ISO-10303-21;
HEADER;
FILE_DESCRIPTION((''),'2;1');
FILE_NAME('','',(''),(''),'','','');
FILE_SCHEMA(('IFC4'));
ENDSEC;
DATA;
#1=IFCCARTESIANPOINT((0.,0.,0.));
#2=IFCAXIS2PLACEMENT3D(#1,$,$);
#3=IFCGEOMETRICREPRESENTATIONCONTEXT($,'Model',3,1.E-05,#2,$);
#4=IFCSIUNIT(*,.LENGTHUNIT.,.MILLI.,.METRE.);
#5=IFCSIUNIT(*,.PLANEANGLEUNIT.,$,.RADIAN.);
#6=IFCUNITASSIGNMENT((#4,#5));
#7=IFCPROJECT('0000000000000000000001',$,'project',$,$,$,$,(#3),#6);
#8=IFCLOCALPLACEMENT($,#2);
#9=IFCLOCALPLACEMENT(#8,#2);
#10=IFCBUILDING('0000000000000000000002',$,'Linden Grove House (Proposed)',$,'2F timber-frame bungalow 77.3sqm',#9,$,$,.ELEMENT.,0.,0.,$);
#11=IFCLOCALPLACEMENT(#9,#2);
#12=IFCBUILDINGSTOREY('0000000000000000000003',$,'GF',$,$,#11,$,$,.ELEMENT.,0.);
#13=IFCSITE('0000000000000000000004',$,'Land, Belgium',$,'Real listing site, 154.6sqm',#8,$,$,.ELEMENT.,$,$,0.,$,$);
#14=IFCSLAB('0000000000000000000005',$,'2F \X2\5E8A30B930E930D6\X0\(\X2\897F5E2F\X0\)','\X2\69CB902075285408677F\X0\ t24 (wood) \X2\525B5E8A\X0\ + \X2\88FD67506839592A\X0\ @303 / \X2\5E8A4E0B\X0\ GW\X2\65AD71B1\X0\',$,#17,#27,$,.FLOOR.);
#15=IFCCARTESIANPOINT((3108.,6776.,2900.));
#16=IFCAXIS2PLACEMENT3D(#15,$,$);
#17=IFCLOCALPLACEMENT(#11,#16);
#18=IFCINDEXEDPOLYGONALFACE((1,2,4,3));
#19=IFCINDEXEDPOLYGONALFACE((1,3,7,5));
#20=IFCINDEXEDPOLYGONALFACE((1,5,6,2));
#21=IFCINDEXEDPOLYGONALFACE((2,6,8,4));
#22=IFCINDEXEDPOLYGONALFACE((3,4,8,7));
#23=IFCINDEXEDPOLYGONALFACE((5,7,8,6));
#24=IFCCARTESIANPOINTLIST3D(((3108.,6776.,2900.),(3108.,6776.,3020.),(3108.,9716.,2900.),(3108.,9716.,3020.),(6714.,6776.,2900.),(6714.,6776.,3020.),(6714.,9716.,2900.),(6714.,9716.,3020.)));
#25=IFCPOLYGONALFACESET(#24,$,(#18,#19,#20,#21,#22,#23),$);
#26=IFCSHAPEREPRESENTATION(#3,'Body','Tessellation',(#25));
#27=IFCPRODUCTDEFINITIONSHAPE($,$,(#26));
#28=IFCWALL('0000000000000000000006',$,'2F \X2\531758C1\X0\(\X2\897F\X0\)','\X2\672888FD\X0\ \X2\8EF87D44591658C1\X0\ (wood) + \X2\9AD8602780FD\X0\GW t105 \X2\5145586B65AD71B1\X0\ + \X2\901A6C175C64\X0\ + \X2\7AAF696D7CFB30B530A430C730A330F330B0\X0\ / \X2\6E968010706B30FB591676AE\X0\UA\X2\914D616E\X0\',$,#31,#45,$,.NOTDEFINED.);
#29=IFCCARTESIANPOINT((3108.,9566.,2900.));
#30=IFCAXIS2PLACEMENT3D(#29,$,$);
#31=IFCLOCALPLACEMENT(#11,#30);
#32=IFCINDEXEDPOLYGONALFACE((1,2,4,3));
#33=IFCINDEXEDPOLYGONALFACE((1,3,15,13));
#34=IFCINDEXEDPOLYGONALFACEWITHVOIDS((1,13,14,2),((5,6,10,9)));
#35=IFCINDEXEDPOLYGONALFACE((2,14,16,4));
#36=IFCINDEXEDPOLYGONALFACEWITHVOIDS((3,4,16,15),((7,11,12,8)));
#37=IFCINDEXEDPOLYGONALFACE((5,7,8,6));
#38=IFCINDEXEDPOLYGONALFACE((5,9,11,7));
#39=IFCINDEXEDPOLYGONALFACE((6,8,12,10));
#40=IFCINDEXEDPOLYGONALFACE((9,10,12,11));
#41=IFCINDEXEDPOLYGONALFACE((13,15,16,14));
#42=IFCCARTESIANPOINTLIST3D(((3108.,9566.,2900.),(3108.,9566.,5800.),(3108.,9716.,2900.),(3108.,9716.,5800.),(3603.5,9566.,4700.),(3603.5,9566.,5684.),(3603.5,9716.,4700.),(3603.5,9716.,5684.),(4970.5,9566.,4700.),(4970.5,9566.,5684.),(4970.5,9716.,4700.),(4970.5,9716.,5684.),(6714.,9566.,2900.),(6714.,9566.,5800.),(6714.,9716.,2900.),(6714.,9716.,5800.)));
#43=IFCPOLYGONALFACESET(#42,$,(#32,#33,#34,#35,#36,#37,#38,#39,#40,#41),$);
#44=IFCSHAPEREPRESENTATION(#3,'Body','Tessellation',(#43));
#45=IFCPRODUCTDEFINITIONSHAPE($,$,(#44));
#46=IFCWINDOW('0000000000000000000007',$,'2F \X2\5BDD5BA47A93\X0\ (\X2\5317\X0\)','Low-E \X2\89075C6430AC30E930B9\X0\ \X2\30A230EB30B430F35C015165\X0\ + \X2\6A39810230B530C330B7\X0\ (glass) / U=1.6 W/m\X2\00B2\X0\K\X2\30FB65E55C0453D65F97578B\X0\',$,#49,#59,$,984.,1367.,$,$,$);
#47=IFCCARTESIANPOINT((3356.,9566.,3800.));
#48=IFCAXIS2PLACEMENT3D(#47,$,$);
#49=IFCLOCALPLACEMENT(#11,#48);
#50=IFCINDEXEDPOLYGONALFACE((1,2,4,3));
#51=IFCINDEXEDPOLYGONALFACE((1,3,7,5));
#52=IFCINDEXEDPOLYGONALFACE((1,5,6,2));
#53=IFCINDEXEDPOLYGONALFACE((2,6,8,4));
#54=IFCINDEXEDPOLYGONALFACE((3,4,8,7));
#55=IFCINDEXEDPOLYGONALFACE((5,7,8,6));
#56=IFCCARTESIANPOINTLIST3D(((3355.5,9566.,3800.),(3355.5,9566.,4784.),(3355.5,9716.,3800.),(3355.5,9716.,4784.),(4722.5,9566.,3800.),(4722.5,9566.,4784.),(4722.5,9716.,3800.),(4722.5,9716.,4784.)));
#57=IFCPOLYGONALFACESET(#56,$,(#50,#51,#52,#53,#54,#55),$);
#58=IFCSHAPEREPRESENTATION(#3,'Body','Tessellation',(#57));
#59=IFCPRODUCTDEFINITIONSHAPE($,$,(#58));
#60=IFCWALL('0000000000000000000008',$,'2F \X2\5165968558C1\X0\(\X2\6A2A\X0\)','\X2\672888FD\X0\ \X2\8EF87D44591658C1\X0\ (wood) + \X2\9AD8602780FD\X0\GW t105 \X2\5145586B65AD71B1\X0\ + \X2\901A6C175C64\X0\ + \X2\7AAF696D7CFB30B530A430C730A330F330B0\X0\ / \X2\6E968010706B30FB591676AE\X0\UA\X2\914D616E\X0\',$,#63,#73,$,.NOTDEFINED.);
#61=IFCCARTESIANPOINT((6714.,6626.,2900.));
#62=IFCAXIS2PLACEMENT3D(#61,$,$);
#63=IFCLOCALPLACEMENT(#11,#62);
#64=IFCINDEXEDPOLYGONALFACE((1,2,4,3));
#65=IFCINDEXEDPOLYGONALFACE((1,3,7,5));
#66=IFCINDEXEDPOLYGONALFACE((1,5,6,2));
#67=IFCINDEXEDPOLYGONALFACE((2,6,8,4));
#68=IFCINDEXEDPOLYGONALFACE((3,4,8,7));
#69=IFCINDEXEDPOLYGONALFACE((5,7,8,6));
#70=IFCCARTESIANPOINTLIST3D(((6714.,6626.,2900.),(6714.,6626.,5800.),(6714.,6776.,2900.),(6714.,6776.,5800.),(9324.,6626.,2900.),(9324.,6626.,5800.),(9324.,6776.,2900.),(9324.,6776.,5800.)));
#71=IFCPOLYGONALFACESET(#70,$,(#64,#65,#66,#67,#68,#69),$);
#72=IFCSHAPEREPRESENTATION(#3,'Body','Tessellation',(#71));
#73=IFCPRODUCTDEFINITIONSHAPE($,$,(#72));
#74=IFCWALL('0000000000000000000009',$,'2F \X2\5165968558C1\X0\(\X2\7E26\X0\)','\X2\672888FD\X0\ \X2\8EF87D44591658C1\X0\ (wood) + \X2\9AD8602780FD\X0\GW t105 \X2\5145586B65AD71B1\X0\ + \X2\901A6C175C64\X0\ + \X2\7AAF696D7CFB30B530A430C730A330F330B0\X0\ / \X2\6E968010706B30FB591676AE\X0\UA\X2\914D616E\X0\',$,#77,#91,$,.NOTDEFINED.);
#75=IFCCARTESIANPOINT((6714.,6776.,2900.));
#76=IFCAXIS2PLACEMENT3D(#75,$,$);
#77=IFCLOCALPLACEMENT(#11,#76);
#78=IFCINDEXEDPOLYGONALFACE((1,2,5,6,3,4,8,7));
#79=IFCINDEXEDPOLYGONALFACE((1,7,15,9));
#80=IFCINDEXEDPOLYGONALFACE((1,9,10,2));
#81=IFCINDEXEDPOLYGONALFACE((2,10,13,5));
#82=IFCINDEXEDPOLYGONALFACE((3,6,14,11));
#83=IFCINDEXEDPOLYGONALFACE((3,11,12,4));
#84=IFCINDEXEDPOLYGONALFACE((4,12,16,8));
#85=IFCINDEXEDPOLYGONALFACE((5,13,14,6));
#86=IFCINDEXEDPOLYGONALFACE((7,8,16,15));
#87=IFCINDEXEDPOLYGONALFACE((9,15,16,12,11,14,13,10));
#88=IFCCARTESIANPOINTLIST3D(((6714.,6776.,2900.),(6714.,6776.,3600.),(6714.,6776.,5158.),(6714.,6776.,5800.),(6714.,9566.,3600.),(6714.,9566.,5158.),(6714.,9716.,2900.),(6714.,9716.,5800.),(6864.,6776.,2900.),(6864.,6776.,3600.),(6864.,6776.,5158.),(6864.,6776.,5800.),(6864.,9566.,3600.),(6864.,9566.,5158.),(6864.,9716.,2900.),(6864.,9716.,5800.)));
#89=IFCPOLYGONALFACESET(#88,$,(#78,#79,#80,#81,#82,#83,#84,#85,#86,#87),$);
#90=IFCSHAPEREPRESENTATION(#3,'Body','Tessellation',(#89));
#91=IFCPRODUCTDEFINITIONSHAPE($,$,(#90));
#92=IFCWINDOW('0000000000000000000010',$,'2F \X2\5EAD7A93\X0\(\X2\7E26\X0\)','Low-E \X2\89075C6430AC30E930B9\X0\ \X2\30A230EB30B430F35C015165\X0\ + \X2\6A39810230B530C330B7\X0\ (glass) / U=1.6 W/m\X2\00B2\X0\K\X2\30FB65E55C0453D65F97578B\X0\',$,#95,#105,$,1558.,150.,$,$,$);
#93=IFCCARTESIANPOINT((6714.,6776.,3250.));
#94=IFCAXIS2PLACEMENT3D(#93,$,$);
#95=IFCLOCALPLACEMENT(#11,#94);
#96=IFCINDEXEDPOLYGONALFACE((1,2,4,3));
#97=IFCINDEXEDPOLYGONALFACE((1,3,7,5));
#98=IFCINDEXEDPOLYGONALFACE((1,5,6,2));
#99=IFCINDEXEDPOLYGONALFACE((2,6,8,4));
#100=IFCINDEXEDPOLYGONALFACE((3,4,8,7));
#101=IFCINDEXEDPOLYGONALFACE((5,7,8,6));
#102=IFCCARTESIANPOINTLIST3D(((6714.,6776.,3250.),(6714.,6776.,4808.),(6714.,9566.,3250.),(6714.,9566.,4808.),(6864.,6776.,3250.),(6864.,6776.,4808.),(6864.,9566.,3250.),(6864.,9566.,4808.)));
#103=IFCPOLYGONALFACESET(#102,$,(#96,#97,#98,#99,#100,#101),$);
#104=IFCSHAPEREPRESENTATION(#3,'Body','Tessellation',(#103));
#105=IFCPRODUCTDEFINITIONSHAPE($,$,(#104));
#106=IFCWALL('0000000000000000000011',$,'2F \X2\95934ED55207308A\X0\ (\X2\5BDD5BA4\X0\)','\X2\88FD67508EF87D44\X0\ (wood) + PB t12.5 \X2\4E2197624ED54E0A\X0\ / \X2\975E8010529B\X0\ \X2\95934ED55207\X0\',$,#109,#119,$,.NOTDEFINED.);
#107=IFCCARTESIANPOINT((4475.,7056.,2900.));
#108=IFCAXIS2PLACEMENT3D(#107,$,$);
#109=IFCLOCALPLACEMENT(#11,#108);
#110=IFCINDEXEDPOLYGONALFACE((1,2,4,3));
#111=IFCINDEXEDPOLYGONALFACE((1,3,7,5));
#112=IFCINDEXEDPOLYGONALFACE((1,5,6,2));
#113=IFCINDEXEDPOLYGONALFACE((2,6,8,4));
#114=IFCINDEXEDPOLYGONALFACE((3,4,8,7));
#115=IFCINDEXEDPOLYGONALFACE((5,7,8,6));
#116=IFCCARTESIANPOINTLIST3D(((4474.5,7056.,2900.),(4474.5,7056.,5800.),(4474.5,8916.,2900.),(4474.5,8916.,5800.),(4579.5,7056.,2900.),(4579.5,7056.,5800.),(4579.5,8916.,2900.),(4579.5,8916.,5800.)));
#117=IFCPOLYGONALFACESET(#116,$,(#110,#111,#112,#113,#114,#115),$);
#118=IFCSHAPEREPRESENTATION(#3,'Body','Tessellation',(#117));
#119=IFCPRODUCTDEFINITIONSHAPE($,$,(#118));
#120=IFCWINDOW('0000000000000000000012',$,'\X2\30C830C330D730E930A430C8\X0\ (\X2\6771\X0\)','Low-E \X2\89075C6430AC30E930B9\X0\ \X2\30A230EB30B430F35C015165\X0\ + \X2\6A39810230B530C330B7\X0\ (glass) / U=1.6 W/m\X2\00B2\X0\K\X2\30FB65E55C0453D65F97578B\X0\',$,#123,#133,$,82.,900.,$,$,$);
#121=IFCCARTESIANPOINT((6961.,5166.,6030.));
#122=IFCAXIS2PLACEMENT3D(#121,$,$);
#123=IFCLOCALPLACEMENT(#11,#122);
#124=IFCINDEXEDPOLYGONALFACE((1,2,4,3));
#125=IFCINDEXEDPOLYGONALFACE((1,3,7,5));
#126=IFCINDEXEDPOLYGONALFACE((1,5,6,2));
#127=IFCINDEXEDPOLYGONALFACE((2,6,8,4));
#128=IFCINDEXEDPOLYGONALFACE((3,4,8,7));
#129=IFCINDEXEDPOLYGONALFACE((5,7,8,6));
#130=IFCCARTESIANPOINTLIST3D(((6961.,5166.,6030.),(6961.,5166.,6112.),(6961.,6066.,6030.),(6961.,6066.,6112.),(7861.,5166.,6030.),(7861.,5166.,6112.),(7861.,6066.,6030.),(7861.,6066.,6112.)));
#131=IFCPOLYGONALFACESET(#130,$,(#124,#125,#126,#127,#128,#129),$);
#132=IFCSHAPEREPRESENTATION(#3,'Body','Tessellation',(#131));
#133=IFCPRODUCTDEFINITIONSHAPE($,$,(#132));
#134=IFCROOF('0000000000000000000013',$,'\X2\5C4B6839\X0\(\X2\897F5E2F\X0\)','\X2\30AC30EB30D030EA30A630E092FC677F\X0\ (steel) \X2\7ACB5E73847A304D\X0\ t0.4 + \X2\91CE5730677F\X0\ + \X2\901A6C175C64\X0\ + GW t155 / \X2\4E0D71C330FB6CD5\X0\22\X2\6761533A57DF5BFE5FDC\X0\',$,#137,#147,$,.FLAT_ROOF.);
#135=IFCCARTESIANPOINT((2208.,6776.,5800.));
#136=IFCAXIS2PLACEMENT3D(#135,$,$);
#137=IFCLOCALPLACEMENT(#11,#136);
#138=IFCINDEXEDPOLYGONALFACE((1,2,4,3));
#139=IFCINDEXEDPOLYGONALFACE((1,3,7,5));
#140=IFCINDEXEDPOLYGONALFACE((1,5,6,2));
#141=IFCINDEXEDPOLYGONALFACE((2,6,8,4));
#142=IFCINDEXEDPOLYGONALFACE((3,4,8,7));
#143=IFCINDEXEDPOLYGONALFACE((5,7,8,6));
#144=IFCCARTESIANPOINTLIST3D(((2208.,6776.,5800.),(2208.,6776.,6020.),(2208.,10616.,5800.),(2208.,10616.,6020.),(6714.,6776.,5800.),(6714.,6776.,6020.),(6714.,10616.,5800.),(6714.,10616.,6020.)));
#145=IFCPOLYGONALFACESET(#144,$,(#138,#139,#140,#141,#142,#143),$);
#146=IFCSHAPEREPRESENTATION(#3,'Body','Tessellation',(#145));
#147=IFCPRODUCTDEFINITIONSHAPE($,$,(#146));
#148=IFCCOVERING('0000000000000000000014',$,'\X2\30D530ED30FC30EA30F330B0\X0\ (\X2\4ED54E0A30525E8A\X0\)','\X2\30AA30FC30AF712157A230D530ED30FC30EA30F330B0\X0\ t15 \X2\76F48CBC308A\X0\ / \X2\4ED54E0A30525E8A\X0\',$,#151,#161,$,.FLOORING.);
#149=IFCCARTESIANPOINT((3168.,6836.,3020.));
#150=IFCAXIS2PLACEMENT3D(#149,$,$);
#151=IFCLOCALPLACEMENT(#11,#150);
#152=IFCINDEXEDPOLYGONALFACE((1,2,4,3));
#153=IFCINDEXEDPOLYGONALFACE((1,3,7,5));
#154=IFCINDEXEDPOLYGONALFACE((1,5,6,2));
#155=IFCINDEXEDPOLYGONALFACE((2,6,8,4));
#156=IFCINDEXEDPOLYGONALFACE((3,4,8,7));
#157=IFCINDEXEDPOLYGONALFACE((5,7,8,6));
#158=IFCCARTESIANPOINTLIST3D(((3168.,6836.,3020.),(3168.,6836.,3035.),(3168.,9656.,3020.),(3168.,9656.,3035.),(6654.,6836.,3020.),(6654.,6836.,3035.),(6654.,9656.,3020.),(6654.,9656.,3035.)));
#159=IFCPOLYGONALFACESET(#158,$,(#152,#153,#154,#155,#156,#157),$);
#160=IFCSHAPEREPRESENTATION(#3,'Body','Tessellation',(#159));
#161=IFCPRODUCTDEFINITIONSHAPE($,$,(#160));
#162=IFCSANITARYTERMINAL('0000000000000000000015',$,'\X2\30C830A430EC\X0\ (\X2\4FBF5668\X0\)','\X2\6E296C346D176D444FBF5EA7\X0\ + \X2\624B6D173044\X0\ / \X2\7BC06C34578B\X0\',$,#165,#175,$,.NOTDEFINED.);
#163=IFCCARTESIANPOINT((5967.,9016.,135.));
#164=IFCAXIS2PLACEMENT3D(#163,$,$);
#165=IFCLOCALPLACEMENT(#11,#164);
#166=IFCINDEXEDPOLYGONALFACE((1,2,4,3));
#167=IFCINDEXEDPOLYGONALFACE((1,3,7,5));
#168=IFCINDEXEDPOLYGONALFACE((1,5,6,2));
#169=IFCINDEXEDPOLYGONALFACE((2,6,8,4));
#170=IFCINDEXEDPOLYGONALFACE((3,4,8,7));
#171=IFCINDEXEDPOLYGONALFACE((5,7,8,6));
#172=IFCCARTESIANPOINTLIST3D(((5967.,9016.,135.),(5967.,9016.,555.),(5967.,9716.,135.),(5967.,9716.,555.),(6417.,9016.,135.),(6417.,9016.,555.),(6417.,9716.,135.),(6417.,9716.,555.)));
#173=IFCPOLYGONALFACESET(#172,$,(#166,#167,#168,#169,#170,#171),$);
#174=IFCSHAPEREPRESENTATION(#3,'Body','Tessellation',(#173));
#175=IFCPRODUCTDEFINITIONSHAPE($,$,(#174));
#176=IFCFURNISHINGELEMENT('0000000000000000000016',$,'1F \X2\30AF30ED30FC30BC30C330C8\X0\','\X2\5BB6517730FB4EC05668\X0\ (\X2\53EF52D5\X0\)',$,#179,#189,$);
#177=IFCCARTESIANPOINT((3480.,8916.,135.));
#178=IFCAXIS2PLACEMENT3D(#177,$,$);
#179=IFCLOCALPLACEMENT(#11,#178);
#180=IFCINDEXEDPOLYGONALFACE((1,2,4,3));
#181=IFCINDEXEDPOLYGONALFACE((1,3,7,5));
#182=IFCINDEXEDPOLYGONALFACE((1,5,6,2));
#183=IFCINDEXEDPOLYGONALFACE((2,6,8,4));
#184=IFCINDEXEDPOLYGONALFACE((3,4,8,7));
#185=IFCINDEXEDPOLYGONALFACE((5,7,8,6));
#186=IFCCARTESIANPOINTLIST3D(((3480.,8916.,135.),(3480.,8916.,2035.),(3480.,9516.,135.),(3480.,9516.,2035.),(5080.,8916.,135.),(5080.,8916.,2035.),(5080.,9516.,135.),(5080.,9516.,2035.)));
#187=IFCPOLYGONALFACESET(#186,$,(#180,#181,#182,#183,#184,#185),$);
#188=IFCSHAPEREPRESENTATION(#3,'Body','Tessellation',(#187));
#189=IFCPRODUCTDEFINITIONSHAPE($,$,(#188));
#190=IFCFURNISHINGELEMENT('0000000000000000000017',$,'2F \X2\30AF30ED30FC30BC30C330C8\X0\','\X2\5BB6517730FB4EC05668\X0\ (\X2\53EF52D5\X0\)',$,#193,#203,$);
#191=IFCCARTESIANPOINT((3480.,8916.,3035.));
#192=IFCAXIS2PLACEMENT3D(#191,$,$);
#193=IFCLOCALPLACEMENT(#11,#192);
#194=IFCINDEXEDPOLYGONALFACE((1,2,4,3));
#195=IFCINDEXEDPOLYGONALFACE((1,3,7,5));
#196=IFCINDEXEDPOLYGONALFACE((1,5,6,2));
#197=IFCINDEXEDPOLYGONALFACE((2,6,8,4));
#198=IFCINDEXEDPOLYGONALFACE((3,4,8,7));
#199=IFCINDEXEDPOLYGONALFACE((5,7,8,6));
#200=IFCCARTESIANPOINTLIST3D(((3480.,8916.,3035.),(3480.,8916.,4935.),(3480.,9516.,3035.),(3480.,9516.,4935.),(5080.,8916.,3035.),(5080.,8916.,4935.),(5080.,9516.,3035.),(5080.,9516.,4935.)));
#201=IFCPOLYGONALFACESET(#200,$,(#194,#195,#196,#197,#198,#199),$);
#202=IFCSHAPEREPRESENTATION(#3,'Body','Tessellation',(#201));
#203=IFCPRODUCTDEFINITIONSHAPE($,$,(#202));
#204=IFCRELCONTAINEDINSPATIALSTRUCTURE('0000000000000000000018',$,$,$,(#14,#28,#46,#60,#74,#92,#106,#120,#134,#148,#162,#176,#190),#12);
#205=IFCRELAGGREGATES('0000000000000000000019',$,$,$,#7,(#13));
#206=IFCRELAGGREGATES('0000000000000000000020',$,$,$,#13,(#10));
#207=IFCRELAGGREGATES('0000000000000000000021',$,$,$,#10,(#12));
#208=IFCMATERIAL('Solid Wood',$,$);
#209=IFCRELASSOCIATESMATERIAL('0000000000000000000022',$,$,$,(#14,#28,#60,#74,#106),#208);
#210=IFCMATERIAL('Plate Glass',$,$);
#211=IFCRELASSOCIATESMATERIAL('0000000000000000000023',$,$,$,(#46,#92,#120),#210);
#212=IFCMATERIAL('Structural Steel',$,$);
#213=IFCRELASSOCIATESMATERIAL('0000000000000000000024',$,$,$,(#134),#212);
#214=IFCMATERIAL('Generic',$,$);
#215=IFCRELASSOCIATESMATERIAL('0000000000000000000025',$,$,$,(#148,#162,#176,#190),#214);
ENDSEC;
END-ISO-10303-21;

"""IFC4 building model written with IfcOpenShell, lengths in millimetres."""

from ifc_helpers import new_model, si_unit, frame, frame_2d, origin, place, context, project, spatial, rectangle, extrude, material, element, fill, save


model = new_model("IFC4")

# Units and contexts
model_context = context("Model", 3, precision=1e-05, world=origin())
ifc_project = project(units=[si_unit("LENGTHUNIT", "METRE", prefix="MILLI"), si_unit("PLANEANGLEUNIT", "RADIAN")], contexts=[model_context])

# Site, building, storey
site_placement = place(None, origin())
site = spatial("IfcSite", under=ifc_project, at=site_placement, Name="Land, Belgium", ObjectType="Real listing site, 154.6sqm", CompositionType="ELEMENT", RefElevation=0.0)
building_placement = place(site_placement, origin())
building = spatial("IfcBuilding", under=site, at=building_placement, Name="Linden Grove House (Proposed)", ObjectType="2F timber-frame bungalow 77.3sqm", CompositionType="ELEMENT", ElevationOfRefHeight=0.0, ElevationOfTerrain=0.0)
storey_placement = place(building_placement, origin())
storey = spatial("IfcBuildingStorey", under=building, at=storey_placement, Name="GF", CompositionType="ELEMENT", Elevation=0.0)

# Slab
ifc_material_1 = material(Name="Solid Wood")
slab_placement = place(storey_placement, frame((3108.0, 6776.0, 2900.0)))
element("IfcSlab", 1, at=slab_placement, inside=storey, material=ifc_material_1, Name="2F 床スラブ(西帯)", Description="構造用合板 t24 (wood) 剛床 + 製材根太 @303 / 床下 GW断熱", PredefinedType="FLOOR", context=model_context, shape_type="SweptSolid", body=[
    extrude(rectangle(XDim=3606.0, YDim=2940.0, at=frame_2d((1803.0, 1470.0))), frame((3108.0, 6776.0, 2900.0)), (0.0, 0.0, 1.0), 120.0),
])

# Wall, opening, window
wall_1_placement = place(storey_placement, frame((3108.0, 9566.0, 2900.0)))
wall_1 = element("IfcWall", 2, at=wall_1_placement, inside=storey, material=ifc_material_1, Name="2F 北壁(西)", Description="木製 軸組外壁 (wood) + 高性能GW t105 充填断熱 + 通気層 + 窯業系サイディング / 準耐火・外皮UA配慮", PredefinedType="NOTDEFINED", context=model_context, shape_type="SweptSolid", body=[
    extrude(rectangle(XDim=3606.0, YDim=150.0, at=frame_2d((1803.0, 75.0))), frame((3108.0, 9566.0, 2900.0)), (0.0, 0.0, 1.0), 2900.0),
])
opening_1_placement = place(storey_placement, frame((3356.0, 9566.0, 3800.0)))
opening_1 = element("IfcOpeningElement", 3, at=opening_1_placement, cuts=wall_1, PredefinedType="NOTDEFINED", context=model_context, shape_type="SweptSolid", body=[
    extrude(rectangle(XDim=1367.0, YDim=150.0, at=frame_2d((683.0, 75.0))), frame((3356.0, 9566.0, 3800.0)), (0.0, 0.0, 1.0), 984.0),
])
ifc_material_2 = material(Name="Plate Glass")
window_1_placement = place(storey_placement, frame((3356.0, 9566.0, 3800.0)))
window_1 = element("IfcWindow", 4, at=window_1_placement, inside=storey, material=ifc_material_2, Name="2F 寝室窓 (北)", Description="Low-E 複層ガラス アルゴン封入 + 樹脂サッシ (glass) / U=1.6 W/m²K・日射取得型", OverallHeight=984.0, OverallWidth=1367.0, context=model_context, shape_type="SweptSolid", body=[
    extrude(rectangle(XDim=1367.0, YDim=150.0, at=frame_2d((683.0, 75.0))), frame((3356.0, 9566.0, 3800.0)), (0.0, 0.0, 1.0), 984.0),
])
fill(opening_1, window_1)

# Wall
wall_2_placement = place(storey_placement, frame((6714.0, 6626.0, 2900.0)))
element("IfcWall", 5, at=wall_2_placement, inside=storey, material=ifc_material_1, Name="2F 入隅壁(横)", Description="木製 軸組外壁 (wood) + 高性能GW t105 充填断熱 + 通気層 + 窯業系サイディング / 準耐火・外皮UA配慮", PredefinedType="NOTDEFINED", context=model_context, shape_type="SweptSolid", body=[
    extrude(rectangle(XDim=2610.0, YDim=150.0, at=frame_2d((1305.0, 75.0))), frame((6714.0, 6626.0, 2900.0)), (0.0, 0.0, 1.0), 2900.0),
])

# Wall, opening, window
wall_3_placement = place(storey_placement, frame((6714.0, 6776.0, 2900.0)))
wall_3 = element("IfcWall", 6, at=wall_3_placement, inside=storey, material=ifc_material_1, Name="2F 入隅壁(縦)", Description="木製 軸組外壁 (wood) + 高性能GW t105 充填断熱 + 通気層 + 窯業系サイディング / 準耐火・外皮UA配慮", PredefinedType="NOTDEFINED", context=model_context, shape_type="SweptSolid", body=[
    extrude(rectangle(XDim=150.0, YDim=2940.0, at=frame_2d((75.0, 1470.0))), frame((6714.0, 6776.0, 2900.0)), (0.0, 0.0, 1.0), 2900.0),
])
opening_2_placement = place(storey_placement, frame((6714.0, 6776.0, 3250.0)))
opening_2 = element("IfcOpeningElement", 7, at=opening_2_placement, cuts=wall_3, PredefinedType="NOTDEFINED", context=model_context, shape_type="SweptSolid", body=[
    extrude(rectangle(XDim=150.0, YDim=2790.0, at=frame_2d((75.0, 1395.0))), frame((6714.0, 6776.0, 3250.0)), (0.0, 0.0, 1.0), 1558.0),
])
window_2_placement = place(storey_placement, frame((6714.0, 6776.0, 3250.0)))
window_2 = element("IfcWindow", 8, at=window_2_placement, inside=storey, material=ifc_material_2, Name="2F 庭窓(縦)", Description="Low-E 複層ガラス アルゴン封入 + 樹脂サッシ (glass) / U=1.6 W/m²K・日射取得型", OverallHeight=1558.0, OverallWidth=150.0, context=model_context, shape_type="SweptSolid", body=[
    extrude(rectangle(XDim=150.0, YDim=2790.0, at=frame_2d((75.0, 1395.0))), frame((6714.0, 6776.0, 3250.0)), (0.0, 0.0, 1.0), 1558.0),
])
fill(opening_2, window_2)

# Wall
wall_4_placement = place(storey_placement, frame((4475.0, 7056.0, 2900.0)))
element("IfcWall", 9, at=wall_4_placement, inside=storey, material=ifc_material_1, Name="2F 間仕切り (寝室)", Description="製材軸組 (wood) + PB t12.5 両面仕上 / 非耐力 間仕切", PredefinedType="NOTDEFINED", context=model_context, shape_type="SweptSolid", body=[
    extrude(rectangle(XDim=105.0, YDim=1860.0, at=frame_2d((52.0, 930.0))), frame((4475.0, 7056.0, 2900.0)), (0.0, 0.0, 1.0), 2900.0),
])

# Window
window_3_placement = place(storey_placement, frame((6961.0, 5166.0, 6030.0)))
element("IfcWindow", 10, at=window_3_placement, inside=storey, material=ifc_material_2, Name="トップライト (東)", Description="Low-E 複層ガラス アルゴン封入 + 樹脂サッシ (glass) / U=1.6 W/m²K・日射取得型", OverallHeight=82.0, OverallWidth=900.0, context=model_context, shape_type="SweptSolid", body=[
    extrude(rectangle(XDim=900.0, YDim=900.0, at=frame_2d((450.0, 450.0))), frame((6961.0, 5166.0, 6030.0)), (0.0, 0.0, 1.0), 82.0),
])

# Roof
ifc_material_3 = material(Name="Structural Steel")
for number, where, name in (
    (11, (2208.0, 6776.0, 5800.0), "屋根(西帯)"),
):
    element("IfcRoof", number, at=place(storey_placement, frame(where)), inside=storey, material=ifc_material_3, Name=name, Description="ガルバリウム鋼板 (steel) 立平葺き t0.4 + 野地板 + 通気層 + GW t155 / 不燃・法22条区域対応", PredefinedType="FLAT_ROOF", context=model_context, shape_type="SweptSolid", body=[
        extrude(rectangle(XDim=4506.0, YDim=3840.0, at=frame_2d((2253.0, 1920.0))), frame((2208.0, 6776.0, 5800.0)), (0.0, 0.0, 1.0), 220.0),
    ])

# Covering
ifc_material_4 = material(Name="Generic")
covering_placement = place(storey_placement, frame((3168.0, 6836.0, 3020.0)))
element("IfcCovering", 12, at=covering_placement, inside=storey, material=ifc_material_4, Name="フローリング (仕上げ床)", Description="オーク無垢フローリング t15 直貼り / 仕上げ床", PredefinedType="FLOORING", context=model_context, shape_type="SweptSolid", body=[
    extrude(rectangle(XDim=3486.0, YDim=2820.0, at=frame_2d((1743.0, 1410.0))), frame((3168.0, 6836.0, 3020.0)), (0.0, 0.0, 1.0), 15.0),
])

# Sanitary terminal
sanitary_terminal_placement = place(storey_placement, frame((5967.0, 9016.0, 135.0)))
element("IfcSanitaryTerminal", 13, at=sanitary_terminal_placement, inside=storey, material=ifc_material_4, Name="トイレ (便器)", Description="温水洗浄便座 + 手洗い / 節水型", PredefinedType="NOTDEFINED", context=model_context, shape_type="SweptSolid", body=[
    extrude(rectangle(XDim=450.0, YDim=700.0, at=frame_2d((225.0, 350.0))), frame((5967.0, 9016.0, 135.0)), (0.0, 0.0, 1.0), 420.0),
])

# Furnishing elements
furnishing_1_placement = place(storey_placement, frame((3480.0, 8916.0, 135.0)))
element("IfcFurnishingElement", 14, at=furnishing_1_placement, inside=storey, material=ifc_material_4, Name="1F クローゼット", Description="家具・什器 (可動)", context=model_context, shape_type="SweptSolid", body=[
    extrude(rectangle(XDim=1600.0, YDim=600.0, at=frame_2d((800.0, 300.0))), frame((3480.0, 8916.0, 135.0)), (0.0, 0.0, 1.0), 1900.0),
])
furnishing_2_placement = place(storey_placement, frame((3480.0, 8916.0, 3035.0)))
element("IfcFurnishingElement", 15, at=furnishing_2_placement, inside=storey, material=ifc_material_4, Name="2F クローゼット", Description="家具・什器 (可動)", context=model_context, shape_type="SweptSolid", body=[
    extrude(rectangle(XDim=1600.0, YDim=600.0, at=frame_2d((800.0, 300.0))), frame((3480.0, 8916.0, 3035.0)), (0.0, 0.0, 1.0), 1900.0),
])

save(model, "model.ifc")
